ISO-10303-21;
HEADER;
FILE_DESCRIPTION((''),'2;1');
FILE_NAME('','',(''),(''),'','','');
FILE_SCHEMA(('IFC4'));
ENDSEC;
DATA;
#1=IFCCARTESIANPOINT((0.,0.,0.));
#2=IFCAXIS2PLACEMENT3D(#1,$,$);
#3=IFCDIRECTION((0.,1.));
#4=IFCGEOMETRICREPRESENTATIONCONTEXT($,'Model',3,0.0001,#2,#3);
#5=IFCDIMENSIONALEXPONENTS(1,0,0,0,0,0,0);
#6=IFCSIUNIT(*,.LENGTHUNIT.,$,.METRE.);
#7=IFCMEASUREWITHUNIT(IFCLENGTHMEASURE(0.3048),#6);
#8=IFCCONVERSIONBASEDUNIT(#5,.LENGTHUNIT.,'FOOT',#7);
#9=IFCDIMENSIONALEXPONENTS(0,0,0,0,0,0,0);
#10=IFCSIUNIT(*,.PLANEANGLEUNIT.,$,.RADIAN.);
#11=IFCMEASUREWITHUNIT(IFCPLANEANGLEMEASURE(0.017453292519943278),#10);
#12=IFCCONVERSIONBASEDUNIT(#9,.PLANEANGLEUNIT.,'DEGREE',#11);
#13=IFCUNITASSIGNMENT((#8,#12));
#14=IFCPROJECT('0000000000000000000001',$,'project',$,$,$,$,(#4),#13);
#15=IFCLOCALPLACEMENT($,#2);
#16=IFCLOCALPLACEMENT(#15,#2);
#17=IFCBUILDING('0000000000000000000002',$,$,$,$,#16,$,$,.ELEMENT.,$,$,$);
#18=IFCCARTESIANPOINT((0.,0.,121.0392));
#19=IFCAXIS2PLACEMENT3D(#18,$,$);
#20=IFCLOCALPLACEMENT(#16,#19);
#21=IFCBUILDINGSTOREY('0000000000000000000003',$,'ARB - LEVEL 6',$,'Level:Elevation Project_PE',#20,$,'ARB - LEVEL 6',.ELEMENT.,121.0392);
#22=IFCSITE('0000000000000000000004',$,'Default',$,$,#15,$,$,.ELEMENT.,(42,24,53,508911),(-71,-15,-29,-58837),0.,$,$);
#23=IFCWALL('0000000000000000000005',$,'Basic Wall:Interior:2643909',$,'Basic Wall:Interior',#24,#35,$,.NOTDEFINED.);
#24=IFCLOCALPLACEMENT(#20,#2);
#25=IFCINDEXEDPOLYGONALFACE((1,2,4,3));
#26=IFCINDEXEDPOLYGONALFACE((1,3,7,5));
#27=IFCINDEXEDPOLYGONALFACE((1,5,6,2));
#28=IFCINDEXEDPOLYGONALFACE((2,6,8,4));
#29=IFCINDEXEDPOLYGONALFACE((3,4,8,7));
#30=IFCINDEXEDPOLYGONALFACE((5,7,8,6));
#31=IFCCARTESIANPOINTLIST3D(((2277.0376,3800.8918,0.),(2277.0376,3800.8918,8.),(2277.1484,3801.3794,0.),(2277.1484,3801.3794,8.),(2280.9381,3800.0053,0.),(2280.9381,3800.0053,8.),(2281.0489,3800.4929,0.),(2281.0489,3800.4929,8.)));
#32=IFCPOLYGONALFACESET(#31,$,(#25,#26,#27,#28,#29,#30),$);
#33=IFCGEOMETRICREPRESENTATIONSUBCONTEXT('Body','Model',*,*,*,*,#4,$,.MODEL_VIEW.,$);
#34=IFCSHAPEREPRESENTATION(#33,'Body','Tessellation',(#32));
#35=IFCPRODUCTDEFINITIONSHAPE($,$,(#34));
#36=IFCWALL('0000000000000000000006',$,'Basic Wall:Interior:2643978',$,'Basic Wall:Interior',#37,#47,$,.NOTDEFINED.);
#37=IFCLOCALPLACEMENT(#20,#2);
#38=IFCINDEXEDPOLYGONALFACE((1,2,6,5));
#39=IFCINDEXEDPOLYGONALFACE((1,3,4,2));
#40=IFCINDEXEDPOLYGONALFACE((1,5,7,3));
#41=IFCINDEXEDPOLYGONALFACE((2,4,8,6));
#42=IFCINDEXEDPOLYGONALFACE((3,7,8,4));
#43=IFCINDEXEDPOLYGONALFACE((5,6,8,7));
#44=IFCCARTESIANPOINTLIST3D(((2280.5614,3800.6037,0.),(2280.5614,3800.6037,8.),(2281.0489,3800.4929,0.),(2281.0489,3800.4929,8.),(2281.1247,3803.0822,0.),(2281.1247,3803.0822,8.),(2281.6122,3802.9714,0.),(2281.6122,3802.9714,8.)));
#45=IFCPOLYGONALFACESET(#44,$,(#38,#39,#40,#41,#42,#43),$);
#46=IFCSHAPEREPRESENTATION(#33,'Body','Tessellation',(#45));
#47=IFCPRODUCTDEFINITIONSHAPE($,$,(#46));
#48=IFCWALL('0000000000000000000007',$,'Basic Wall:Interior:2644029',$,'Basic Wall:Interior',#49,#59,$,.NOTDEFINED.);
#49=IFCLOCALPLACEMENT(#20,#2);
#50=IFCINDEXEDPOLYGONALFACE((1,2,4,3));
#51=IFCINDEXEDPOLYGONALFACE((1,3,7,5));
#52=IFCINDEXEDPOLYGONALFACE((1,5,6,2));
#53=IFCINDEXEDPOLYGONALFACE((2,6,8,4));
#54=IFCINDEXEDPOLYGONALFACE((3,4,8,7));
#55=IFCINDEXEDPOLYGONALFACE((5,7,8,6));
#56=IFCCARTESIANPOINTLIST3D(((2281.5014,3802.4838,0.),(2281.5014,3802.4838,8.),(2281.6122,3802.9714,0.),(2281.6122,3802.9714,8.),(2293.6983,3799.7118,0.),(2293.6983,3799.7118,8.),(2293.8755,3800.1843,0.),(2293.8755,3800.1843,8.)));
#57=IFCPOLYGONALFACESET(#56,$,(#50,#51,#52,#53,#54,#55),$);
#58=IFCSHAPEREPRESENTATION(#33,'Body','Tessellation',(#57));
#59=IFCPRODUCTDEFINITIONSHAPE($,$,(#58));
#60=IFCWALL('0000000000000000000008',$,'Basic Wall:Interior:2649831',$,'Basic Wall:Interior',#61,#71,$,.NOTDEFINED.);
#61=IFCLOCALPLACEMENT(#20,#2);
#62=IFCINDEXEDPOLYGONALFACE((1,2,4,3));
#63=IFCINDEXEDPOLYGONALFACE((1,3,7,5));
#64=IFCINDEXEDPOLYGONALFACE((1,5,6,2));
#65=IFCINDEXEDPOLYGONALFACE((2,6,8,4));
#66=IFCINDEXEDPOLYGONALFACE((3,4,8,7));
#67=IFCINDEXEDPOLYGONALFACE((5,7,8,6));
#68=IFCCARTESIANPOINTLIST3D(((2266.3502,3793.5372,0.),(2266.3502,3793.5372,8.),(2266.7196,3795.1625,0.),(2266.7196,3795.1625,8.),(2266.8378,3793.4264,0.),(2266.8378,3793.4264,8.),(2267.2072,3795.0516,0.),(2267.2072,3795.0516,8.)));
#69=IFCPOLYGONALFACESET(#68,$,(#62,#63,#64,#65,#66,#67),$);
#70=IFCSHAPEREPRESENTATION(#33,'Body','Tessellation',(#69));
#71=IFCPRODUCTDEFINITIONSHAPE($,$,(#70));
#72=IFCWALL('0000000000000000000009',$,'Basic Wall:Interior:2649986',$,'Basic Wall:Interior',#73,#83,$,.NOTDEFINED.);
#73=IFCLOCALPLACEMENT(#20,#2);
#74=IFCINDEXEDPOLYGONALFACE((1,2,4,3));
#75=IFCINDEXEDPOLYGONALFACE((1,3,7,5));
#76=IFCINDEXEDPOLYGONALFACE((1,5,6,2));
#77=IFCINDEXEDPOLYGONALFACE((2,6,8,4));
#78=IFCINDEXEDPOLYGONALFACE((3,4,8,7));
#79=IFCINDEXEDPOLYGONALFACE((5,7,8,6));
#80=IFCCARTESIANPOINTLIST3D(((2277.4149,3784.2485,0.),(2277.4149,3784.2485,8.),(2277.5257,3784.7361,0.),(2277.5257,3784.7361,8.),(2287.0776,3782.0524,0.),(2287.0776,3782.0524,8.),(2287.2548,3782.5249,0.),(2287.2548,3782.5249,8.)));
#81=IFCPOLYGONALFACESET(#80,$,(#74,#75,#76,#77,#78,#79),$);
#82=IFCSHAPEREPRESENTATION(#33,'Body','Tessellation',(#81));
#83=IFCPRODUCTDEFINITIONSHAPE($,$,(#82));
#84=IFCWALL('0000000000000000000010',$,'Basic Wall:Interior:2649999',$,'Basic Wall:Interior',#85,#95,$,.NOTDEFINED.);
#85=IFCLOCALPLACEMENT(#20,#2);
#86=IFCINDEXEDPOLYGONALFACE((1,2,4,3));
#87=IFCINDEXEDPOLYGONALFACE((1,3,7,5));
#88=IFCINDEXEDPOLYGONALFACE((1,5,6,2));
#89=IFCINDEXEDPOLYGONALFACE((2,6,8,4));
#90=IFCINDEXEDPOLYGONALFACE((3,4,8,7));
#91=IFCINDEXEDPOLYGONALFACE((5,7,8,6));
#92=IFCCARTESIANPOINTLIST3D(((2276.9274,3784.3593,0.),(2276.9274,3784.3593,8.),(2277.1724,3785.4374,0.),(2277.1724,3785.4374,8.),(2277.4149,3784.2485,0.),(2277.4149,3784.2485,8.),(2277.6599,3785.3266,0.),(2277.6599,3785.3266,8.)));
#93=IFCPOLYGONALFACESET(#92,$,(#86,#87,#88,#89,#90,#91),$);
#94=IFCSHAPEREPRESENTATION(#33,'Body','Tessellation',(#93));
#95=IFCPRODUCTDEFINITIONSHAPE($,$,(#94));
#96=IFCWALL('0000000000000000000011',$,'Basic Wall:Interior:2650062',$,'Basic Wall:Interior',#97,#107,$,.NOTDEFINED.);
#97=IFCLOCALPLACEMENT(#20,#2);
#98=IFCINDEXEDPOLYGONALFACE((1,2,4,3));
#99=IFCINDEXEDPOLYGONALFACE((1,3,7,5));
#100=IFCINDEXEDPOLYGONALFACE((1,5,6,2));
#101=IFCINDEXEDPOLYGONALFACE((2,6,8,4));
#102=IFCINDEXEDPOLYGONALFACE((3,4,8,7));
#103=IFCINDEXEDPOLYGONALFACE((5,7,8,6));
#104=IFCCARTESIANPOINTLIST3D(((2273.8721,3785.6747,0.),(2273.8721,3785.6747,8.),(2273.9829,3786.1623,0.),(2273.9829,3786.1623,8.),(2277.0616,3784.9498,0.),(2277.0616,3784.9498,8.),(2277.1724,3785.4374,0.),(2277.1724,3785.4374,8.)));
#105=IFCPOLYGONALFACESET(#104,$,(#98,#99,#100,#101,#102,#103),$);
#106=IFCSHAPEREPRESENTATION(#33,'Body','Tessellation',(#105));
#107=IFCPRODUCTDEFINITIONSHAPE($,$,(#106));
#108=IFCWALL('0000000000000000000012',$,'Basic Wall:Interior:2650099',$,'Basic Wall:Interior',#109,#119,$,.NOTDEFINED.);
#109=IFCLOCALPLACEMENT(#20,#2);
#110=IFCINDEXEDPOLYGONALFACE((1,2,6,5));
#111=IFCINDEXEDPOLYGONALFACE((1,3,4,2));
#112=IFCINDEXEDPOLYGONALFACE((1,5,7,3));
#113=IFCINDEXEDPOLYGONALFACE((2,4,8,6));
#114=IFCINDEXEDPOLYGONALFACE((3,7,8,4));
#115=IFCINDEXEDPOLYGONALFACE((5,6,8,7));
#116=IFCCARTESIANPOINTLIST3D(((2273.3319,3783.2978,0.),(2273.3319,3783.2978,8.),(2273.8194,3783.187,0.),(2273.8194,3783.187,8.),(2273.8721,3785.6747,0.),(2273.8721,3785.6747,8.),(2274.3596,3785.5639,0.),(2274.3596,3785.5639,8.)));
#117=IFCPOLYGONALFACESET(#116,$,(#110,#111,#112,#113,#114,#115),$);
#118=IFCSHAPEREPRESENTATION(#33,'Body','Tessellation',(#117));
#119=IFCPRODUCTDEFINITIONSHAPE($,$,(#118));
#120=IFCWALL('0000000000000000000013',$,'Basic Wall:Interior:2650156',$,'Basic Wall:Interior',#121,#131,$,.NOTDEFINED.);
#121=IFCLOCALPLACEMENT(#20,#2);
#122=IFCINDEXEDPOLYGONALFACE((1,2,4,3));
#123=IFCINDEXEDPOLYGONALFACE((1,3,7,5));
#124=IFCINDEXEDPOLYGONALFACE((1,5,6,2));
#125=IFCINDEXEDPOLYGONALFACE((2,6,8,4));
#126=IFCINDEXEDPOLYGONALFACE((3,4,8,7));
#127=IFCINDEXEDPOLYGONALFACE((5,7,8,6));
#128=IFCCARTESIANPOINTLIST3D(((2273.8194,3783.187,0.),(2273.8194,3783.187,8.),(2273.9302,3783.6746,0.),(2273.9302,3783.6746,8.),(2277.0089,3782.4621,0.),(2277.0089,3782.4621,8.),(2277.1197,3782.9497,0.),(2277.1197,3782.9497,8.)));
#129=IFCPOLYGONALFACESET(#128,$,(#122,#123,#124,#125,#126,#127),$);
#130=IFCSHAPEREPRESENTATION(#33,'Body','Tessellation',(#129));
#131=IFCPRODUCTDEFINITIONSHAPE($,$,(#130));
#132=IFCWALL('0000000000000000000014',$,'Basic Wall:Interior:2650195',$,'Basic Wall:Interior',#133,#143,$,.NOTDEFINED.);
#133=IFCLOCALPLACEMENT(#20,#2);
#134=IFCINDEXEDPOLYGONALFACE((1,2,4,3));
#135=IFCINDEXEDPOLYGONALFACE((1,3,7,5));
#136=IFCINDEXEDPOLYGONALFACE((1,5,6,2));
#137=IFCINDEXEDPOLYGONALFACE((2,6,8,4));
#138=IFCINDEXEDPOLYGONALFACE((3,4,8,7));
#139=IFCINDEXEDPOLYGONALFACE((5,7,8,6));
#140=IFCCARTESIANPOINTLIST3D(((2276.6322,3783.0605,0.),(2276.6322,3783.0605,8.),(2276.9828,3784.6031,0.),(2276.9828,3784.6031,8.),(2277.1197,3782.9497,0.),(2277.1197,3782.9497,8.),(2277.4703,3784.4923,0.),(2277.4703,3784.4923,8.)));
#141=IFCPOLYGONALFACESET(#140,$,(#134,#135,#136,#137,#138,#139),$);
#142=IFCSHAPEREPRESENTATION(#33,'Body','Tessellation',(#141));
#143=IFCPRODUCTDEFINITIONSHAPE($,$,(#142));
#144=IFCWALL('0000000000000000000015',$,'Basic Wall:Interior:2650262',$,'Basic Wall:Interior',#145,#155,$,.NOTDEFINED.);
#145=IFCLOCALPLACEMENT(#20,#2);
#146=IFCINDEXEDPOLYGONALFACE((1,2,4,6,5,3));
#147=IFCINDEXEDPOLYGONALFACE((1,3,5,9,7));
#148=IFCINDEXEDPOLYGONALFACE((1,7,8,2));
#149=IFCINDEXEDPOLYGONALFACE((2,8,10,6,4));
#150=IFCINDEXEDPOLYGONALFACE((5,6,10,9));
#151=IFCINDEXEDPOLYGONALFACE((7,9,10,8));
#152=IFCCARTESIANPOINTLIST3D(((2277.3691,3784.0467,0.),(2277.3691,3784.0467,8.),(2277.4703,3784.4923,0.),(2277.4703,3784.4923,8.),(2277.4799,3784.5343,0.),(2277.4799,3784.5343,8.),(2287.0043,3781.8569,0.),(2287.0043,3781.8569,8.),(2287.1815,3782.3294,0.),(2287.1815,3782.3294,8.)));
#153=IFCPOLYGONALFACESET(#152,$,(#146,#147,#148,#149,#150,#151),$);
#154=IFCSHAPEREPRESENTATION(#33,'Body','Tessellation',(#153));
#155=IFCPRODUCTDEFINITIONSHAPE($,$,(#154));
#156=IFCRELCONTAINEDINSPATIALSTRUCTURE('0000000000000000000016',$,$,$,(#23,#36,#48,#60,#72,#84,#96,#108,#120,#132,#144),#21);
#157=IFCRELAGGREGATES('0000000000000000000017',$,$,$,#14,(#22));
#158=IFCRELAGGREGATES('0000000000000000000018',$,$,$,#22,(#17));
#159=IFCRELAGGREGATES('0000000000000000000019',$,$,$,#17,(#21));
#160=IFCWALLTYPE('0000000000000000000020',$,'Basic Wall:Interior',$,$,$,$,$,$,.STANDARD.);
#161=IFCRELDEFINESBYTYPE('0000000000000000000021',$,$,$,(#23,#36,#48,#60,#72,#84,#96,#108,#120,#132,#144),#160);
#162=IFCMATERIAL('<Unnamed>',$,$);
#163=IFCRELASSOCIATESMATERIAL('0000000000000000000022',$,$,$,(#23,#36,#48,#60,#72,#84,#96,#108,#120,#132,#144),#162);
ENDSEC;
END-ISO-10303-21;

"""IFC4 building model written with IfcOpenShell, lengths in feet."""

from ifc_helpers import new_model, entity, si_unit, converted_unit, direction, frame, origin, place, context, subcontext, project, spatial, indexed_curve, outline, extrude, material, type_object, element, save


model = new_model("IFC4")

# Units and contexts
model_context = context("Model", 3, precision=0.0001, world=origin(), true_north=direction((0.0, 1.0)))
body_context = subcontext(model_context, "Body", "Model", "MODEL_VIEW")
ifc_project = project(units=[converted_unit("LENGTHUNIT", "FOOT", entity("IfcLengthMeasure", 0.3048), si_unit("LENGTHUNIT", "METRE"), dimensions=[1, 0, 0, 0, 0, 0, 0]), converted_unit("PLANEANGLEUNIT", "DEGREE", entity("IfcPlaneAngleMeasure", 0.017453292519943278), si_unit("PLANEANGLEUNIT", "RADIAN"), dimensions=[0, 0, 0, 0, 0, 0, 0])], contexts=[model_context])

# Site, building, storey
site_placement = place(None, origin())
site = spatial("IfcSite", under=ifc_project, at=site_placement, Name="Default", CompositionType="ELEMENT", RefLatitude=(42, 24, 53, 508911), RefLongitude=(-71, -15, -29, -58837), RefElevation=0.0)
building_placement = place(site_placement, origin())
building = spatial("IfcBuilding", under=site, at=building_placement, CompositionType="ELEMENT")
storey_placement = place(building_placement, frame((0.0, 0.0, 121.0392)))
storey = spatial("IfcBuildingStorey", under=building, at=storey_placement, Name="ARB - LEVEL 6", ObjectType="Level:Elevation Project_PE", LongName="ARB - LEVEL 6", CompositionType="ELEMENT", Elevation=121.0392)

# Walls
ifc_material = material(Name="<Unnamed>")
wall_type = type_object("IfcWallType", Name="Basic Wall:Interior", PredefinedType="STANDARD")
wall_1_placement = place(storey_placement, frame((2277.093, 3801.1356, 0.0), z_axis=(0.0, 0.0, 1.0), x_axis=(0.975133, -0.221622, 0.0)))
element("IfcWall", 1, at=wall_1_placement, inside=storey, type_object=wall_type, material=ifc_material, Name="Basic Wall:Interior:2643909", ObjectType="Basic Wall:Interior", PredefinedType="NOTDEFINED", context=body_context, shape_type="SweptSolid", body=[
    extrude(outline(indexed_curve([(4.0, 0.25), (0.0, 0.25), (0.0, -0.25), (4.0, -0.25), (4.0, 0.25)], self_intersect=False)), origin(), (0.0, 0.0, 1.0), 8.0),
])
wall_2_placement = place(storey_placement, frame((2280.8052, 3800.5483, 0.0), z_axis=(0.0, 0.0, 1.0), x_axis=(0.221622, 0.975133, 0.0)))
element("IfcWall", 2, at=wall_2_placement, inside=storey, type_object=wall_type, material=ifc_material, Name="Basic Wall:Interior:2643978", ObjectType="Basic Wall:Interior", PredefinedType="NOTDEFINED", context=body_context, shape_type="SweptSolid", body=[
    extrude(outline(indexed_curve([(2.5417, 0.25), (0.0, 0.25), (0.0, -0.25), (2.5417, -0.25), (2.5417, 0.25)], self_intersect=False)), origin(), (0.0, 0.0, 1.0), 8.0),
])
wall_3_placement = place(storey_placement, frame((2281.5568, 3802.7276, 0.0), z_axis=(0.0, 0.0, 1.0), x_axis=(0.975133, -0.221622, 0.0)))
element("IfcWall", 3, at=wall_3_placement, inside=storey, type_object=wall_type, material=ifc_material, Name="Basic Wall:Interior:2644029", ObjectType="Basic Wall:Interior", PredefinedType="NOTDEFINED", context=body_context, shape_type="SweptSolid", body=[
    extrude(outline(indexed_curve([(12.508, -0.25), (12.576, 0.25), (0.0, 0.25), (0.0, -0.25), (12.508, -0.25)], self_intersect=False)), origin(), (0.0, 0.0, 1.0), 8.0),
])
wall_4_placement = place(storey_placement, frame((2266.594, 3793.4818, 0.0), z_axis=(0.0, 0.0, 1.0), x_axis=(0.221622, 0.975133, 0.0)))
element("IfcWall", 4, at=wall_4_placement, inside=storey, type_object=wall_type, material=ifc_material, Name="Basic Wall:Interior:2649831", ObjectType="Basic Wall:Interior", PredefinedType="NOTDEFINED", context=body_context, shape_type="SweptSolid", body=[
    extrude(outline(indexed_curve([(1.6667, 0.25), (0.0, 0.25), (0.0, -0.25), (1.6667, -0.25), (1.6667, 0.25)], self_intersect=False)), origin(), (0.0, 0.0, 1.0), 8.0),
])
wall_5_placement = place(storey_placement, frame((2287.1994, 3782.2811, 0.0), z_axis=(0.0, 0.0, 1.0), x_axis=(-0.975133, 0.221622, 0.0)))
element("IfcWall", 5, at=wall_5_placement, inside=storey, type_object=wall_type, material=ifc_material, Name="Basic Wall:Interior:2649986", ObjectType="Basic Wall:Interior", PredefinedType="NOTDEFINED", context=body_context, shape_type="SweptSolid", body=[
    extrude(outline(indexed_curve([(9.9771, -0.25), (9.9771, 0.25), (0.068, 0.25), (0.0, -0.25), (9.9771, -0.25)], self_intersect=False)), origin(), (0.0, 0.0, 1.0), 8.0),
])
wall_6_placement = place(storey_placement, frame((2277.1711, 3784.3039, 0.0), z_axis=(0.0, 0.0, 1.0), x_axis=(0.221622, 0.975133, 0.0)))
element("IfcWall", 6, at=wall_6_placement, inside=storey, type_object=wall_type, material=ifc_material, Name="Basic Wall:Interior:2649999", ObjectType="Basic Wall:Interior", PredefinedType="NOTDEFINED", context=body_context, shape_type="SweptSolid", body=[
    extrude(outline(indexed_curve([(1.1056, 0.25), (0.0, 0.25), (0.0, -0.25), (1.1056, -0.25), (1.1056, 0.25)], self_intersect=False)), origin(), (0.0, 0.0, 1.0), 8.0),
])
wall_7_placement = place(storey_placement, frame((2277.117, 3785.1936, 0.0), z_axis=(0.0, 0.0, 1.0), x_axis=(-0.975133, 0.221622, 0.0)))
element("IfcWall", 7, at=wall_7_placement, inside=storey, type_object=wall_type, material=ifc_material, Name="Basic Wall:Interior:2650062", ObjectType="Basic Wall:Interior", PredefinedType="NOTDEFINED", context=body_context, shape_type="SweptSolid", body=[
    extrude(outline(indexed_curve([(3.2708, 0.25), (0.0, 0.25), (0.0, -0.25), (3.2708, -0.25), (3.2708, 0.25)], self_intersect=False)), origin(), (0.0, 0.0, 1.0), 8.0),
])
wall_8_placement = place(storey_placement, frame((2274.1159, 3785.6193, 0.0), z_axis=(0.0, 0.0, 1.0), x_axis=(-0.221622, -0.975133, 0.0)))
element("IfcWall", 8, at=wall_8_placement, inside=storey, type_object=wall_type, material=ifc_material, Name="Basic Wall:Interior:2650099", ObjectType="Basic Wall:Interior", PredefinedType="NOTDEFINED", context=body_context, shape_type="SweptSolid", body=[
    extrude(outline(indexed_curve([(2.4375, 0.25), (0.0, 0.25), (0.0, -0.25), (2.4375, -0.25), (2.4375, 0.25)], self_intersect=False)), origin(), (0.0, 0.0, 1.0), 8.0),
])
wall_9_placement = place(storey_placement, frame((2273.8748, 3783.4308, 0.0), z_axis=(0.0, 0.0, 1.0), x_axis=(0.975133, -0.221622, 0.0)))
element("IfcWall", 9, at=wall_9_placement, inside=storey, type_object=wall_type, material=ifc_material, Name="Basic Wall:Interior:2650156", ObjectType="Basic Wall:Interior", PredefinedType="NOTDEFINED", context=body_context, shape_type="SweptSolid", body=[
    extrude(outline(indexed_curve([(3.2708, 0.25), (0.0, 0.25), (0.0, -0.25), (3.2708, -0.25), (3.2708, 0.25)], self_intersect=False)), origin(), (0.0, 0.0, 1.0), 8.0),
])
wall_10_placement = place(storey_placement, frame((2276.876, 3783.0051, 0.0), z_axis=(0.0, 0.0, 1.0), x_axis=(0.221622, 0.975133, 0.0)))
element("IfcWall", 10, at=wall_10_placement, inside=storey, type_object=wall_type, material=ifc_material, Name="Basic Wall:Interior:2650195", ObjectType="Basic Wall:Interior", PredefinedType="NOTDEFINED", context=body_context, shape_type="SweptSolid", body=[
    extrude(outline(indexed_curve([(1.5819, 0.25), (0.0, 0.25), (0.0, -0.25), (1.5819, -0.25), (1.5819, 0.25)], self_intersect=False)), origin(), (0.0, 0.0, 1.0), 8.0),
])
wall_11_placement = place(storey_placement, frame((2277.4245, 3784.2905, 0.0), z_axis=(0.0, 0.0, 1.0), x_axis=(0.975133, -0.221622, 0.0)))
element("IfcWall", 11, at=wall_11_placement, inside=storey, type_object=wall_type, material=ifc_material, Name="Basic Wall:Interior:2650262", ObjectType="Basic Wall:Interior", PredefinedType="NOTDEFINED", context=body_context, shape_type="SweptSolid", body=[
    extrude(outline(indexed_curve([(9.881, -0.25), (9.949, 0.25), (0.0, 0.25), (0.0, 0.2069), (0.0, -0.25), (9.881, -0.25)], self_intersect=False)), origin(), (0.0, 0.0, 1.0), 8.0),
])

save(model, "model.ifc")
